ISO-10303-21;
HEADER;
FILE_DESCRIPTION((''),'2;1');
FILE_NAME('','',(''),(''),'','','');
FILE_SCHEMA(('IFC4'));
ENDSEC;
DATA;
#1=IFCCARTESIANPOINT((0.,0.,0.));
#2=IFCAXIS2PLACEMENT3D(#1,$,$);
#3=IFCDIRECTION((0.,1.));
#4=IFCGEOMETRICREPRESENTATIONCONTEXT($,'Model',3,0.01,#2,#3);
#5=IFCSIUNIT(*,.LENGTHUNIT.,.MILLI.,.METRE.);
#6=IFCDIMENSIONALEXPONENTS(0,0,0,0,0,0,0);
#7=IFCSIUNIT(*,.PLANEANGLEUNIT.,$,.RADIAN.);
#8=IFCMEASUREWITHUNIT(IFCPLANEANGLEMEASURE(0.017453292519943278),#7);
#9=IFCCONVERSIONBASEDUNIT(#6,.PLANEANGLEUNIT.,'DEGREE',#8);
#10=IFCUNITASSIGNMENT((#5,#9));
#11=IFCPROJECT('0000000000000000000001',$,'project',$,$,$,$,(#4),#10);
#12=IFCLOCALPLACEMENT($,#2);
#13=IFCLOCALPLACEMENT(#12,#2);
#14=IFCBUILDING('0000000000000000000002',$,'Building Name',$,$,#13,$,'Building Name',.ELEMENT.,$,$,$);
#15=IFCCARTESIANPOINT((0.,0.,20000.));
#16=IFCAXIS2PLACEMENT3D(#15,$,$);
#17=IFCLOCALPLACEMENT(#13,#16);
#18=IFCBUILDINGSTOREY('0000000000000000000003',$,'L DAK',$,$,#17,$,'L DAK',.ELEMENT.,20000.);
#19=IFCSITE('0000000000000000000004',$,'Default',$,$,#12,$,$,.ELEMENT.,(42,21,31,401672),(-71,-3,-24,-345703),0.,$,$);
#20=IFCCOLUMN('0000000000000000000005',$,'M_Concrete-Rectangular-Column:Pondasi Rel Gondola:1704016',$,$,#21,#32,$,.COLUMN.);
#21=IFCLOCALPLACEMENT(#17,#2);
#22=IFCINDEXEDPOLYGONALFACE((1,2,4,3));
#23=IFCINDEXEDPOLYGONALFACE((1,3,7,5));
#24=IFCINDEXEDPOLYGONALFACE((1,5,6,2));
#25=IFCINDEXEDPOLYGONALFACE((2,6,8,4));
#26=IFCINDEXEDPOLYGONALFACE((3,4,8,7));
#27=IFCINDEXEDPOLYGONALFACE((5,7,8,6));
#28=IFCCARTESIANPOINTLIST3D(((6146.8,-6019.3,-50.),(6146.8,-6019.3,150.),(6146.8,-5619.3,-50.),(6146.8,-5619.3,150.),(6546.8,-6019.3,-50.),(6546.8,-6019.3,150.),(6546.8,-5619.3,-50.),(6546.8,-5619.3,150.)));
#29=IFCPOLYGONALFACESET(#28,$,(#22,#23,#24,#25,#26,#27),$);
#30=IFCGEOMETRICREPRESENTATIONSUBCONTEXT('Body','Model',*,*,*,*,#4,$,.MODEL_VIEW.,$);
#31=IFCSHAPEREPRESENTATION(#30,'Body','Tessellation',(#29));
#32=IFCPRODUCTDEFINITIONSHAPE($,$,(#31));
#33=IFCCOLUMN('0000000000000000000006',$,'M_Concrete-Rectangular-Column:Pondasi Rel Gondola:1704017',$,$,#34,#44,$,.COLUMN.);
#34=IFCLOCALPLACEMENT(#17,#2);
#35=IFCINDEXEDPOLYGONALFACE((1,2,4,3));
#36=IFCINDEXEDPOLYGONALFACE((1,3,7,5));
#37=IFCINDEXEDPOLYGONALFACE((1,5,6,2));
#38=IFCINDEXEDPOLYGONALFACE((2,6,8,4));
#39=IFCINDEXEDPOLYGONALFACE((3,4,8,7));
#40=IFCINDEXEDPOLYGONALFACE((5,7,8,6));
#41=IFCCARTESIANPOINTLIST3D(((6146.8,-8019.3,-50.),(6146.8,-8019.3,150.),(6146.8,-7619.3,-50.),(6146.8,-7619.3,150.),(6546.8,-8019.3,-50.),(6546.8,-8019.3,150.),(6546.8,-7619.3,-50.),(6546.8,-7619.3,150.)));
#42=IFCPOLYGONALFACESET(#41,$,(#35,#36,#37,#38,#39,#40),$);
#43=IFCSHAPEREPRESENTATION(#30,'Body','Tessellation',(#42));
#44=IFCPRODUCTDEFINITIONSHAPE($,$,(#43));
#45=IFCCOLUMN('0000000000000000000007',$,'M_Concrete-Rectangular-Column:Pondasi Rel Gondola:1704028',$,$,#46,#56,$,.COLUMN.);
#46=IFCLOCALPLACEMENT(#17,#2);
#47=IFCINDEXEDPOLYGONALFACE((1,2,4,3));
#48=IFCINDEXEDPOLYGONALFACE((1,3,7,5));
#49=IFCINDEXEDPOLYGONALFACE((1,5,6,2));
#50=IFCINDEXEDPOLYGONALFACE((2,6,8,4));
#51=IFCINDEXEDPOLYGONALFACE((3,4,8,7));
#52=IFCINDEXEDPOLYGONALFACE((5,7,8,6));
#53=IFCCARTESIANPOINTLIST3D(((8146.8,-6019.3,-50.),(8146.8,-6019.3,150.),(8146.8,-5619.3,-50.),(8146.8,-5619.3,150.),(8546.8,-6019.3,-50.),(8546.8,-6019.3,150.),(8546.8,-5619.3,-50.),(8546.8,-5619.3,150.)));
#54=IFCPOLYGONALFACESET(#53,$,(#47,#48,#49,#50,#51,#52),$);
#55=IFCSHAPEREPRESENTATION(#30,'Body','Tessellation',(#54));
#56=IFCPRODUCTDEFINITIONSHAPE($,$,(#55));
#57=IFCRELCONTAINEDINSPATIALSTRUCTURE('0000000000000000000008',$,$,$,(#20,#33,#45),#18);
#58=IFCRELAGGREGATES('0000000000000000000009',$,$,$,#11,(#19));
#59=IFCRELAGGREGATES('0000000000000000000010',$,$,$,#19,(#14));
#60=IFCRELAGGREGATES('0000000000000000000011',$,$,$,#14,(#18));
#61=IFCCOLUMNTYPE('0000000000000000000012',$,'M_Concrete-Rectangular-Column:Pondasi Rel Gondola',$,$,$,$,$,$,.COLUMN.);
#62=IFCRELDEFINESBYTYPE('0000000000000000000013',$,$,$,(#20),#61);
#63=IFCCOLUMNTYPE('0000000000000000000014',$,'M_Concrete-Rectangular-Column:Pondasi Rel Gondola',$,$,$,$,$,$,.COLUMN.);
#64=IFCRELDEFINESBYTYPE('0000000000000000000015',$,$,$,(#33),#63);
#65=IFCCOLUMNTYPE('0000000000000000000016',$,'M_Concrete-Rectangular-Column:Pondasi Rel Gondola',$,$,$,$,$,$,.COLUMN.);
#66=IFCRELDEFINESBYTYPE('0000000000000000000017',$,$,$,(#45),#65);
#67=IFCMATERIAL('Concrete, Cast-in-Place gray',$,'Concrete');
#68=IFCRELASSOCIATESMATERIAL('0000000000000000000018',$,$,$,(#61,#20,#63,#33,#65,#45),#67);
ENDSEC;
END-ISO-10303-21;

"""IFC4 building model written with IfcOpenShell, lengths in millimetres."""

from ifc_helpers import new_model, entity, si_unit, converted_unit, direction, frame, origin, place, context, subcontext, project, spatial, indexed_curve, outline, extrude, source, transform, mapped, material, type_object, type_shapes, element, save


model = new_model("IFC4")

# Units and contexts
model_context = context("Model", 3, precision=0.01, world=origin(), true_north=direction((0.0, 1.0)))
body_context = subcontext(model_context, "Body", "Model", "MODEL_VIEW")
ifc_project = project(units=[si_unit("LENGTHUNIT", "METRE", prefix="MILLI"), converted_unit("PLANEANGLEUNIT", "DEGREE", entity("IfcPlaneAngleMeasure", 0.017453292519943278), si_unit("PLANEANGLEUNIT", "RADIAN"), dimensions=[0, 0, 0, 0, 0, 0, 0])], contexts=[model_context])

# Site, building, storey
site_placement = place(None, origin())
site = spatial("IfcSite", under=ifc_project, at=site_placement, Name="Default", CompositionType="ELEMENT", RefLatitude=(42, 21, 31, 401672), RefLongitude=(-71, -3, -24, -345703), RefElevation=0.0)
building_placement = place(site_placement, origin())
building = spatial("IfcBuilding", under=site, at=building_placement, Name="Building Name", LongName="Building Name", CompositionType="ELEMENT")
storey_placement = place(building_placement, frame((0.0, 0.0, 20000.0)))
storey = spatial("IfcBuildingStorey", under=building, at=storey_placement, Name="L DAK", LongName="L DAK", CompositionType="ELEMENT", Elevation=20000.0)

# Columns
ifc_material = material(Name="Concrete, Cast-in-Place gray", Category="Concrete")
column_type_1 = type_object("IfcColumnType", Name="M_Concrete-Rectangular-Column:Pondasi Rel Gondola", PredefinedType="COLUMN", material=ifc_material)
shared_shape_1 = source(origin(), body_context, "Body", "SweptSolid", [
    extrude(outline(indexed_curve([(-200.0, -200.0), (200.0, -200.0), (200.0, 200.0), (-200.0, 200.0), (-200.0, -200.0)], self_intersect=False)), frame((6346.8, -5819.3, 19950.0), z_axis=(0.0, 0.0, 1.0), x_axis=(-1.0, 0.0, 0.0)), (0.0, 0.0, 1.0), 200.0),
])
type_shapes(column_type_1, [shared_shape_1])
column_1_placement = place(storey_placement, frame((0.0, 0.0, -20000.0)))
element("IfcColumn", 1, at=column_1_placement, inside=storey, type_object=column_type_1, material=ifc_material, Name="M_Concrete-Rectangular-Column:Pondasi Rel Gondola:1704016", PredefinedType="COLUMN", context=body_context, shape_type="MappedRepresentation", body=[
    mapped(shared_shape_1, transform((0.0, 0.0, 0.0), scale=1.0)),
])
column_type_2 = type_object("IfcColumnType", Name="M_Concrete-Rectangular-Column:Pondasi Rel Gondola", PredefinedType="COLUMN", material=ifc_material)
shared_shape_2 = source(origin(), body_context, "Body", "SweptSolid", [
    extrude(outline(indexed_curve([(-200.0, -200.0), (200.0, -200.0), (200.0, 200.0), (-200.0, 200.0), (-200.0, -200.0)], self_intersect=False)), frame((6346.8, -7819.3, 19950.0), z_axis=(0.0, 0.0, 1.0), x_axis=(-1.0, 0.0, 0.0)), (0.0, 0.0, 1.0), 200.0),
])
type_shapes(column_type_2, [shared_shape_2])
column_2_placement = place(storey_placement, frame((0.0, 0.0, -20000.0)))
element("IfcColumn", 2, at=column_2_placement, inside=storey, type_object=column_type_2, material=ifc_material, Name="M_Concrete-Rectangular-Column:Pondasi Rel Gondola:1704017", PredefinedType="COLUMN", context=body_context, shape_type="MappedRepresentation", body=[
    mapped(shared_shape_2, transform((0.0, 0.0, 0.0), scale=1.0)),
])
column_type_3 = type_object("IfcColumnType", Name="M_Concrete-Rectangular-Column:Pondasi Rel Gondola", PredefinedType="COLUMN", material=ifc_material)
shared_shape_3 = source(origin(), body_context, "Body", "SweptSolid", [
    extrude(outline(indexed_curve([(-200.0, -200.0), (200.0, -200.0), (200.0, 200.0), (-200.0, 200.0), (-200.0, -200.0)], self_intersect=False)), frame((8346.8, -5819.3, 19950.0), z_axis=(0.0, 0.0, 1.0), x_axis=(-1.0, 0.0, 0.0)), (0.0, 0.0, 1.0), 200.0),
])
type_shapes(column_type_3, [shared_shape_3])
column_3_placement = place(storey_placement, frame((0.0, 0.0, -20000.0)))
element("IfcColumn", 3, at=column_3_placement, inside=storey, type_object=column_type_3, material=ifc_material, Name="M_Concrete-Rectangular-Column:Pondasi Rel Gondola:1704028", PredefinedType="COLUMN", context=body_context, shape_type="MappedRepresentation", body=[
    mapped(shared_shape_3, transform((0.0, 0.0, 0.0), scale=1.0)),
])

save(model, "model.ifc")
